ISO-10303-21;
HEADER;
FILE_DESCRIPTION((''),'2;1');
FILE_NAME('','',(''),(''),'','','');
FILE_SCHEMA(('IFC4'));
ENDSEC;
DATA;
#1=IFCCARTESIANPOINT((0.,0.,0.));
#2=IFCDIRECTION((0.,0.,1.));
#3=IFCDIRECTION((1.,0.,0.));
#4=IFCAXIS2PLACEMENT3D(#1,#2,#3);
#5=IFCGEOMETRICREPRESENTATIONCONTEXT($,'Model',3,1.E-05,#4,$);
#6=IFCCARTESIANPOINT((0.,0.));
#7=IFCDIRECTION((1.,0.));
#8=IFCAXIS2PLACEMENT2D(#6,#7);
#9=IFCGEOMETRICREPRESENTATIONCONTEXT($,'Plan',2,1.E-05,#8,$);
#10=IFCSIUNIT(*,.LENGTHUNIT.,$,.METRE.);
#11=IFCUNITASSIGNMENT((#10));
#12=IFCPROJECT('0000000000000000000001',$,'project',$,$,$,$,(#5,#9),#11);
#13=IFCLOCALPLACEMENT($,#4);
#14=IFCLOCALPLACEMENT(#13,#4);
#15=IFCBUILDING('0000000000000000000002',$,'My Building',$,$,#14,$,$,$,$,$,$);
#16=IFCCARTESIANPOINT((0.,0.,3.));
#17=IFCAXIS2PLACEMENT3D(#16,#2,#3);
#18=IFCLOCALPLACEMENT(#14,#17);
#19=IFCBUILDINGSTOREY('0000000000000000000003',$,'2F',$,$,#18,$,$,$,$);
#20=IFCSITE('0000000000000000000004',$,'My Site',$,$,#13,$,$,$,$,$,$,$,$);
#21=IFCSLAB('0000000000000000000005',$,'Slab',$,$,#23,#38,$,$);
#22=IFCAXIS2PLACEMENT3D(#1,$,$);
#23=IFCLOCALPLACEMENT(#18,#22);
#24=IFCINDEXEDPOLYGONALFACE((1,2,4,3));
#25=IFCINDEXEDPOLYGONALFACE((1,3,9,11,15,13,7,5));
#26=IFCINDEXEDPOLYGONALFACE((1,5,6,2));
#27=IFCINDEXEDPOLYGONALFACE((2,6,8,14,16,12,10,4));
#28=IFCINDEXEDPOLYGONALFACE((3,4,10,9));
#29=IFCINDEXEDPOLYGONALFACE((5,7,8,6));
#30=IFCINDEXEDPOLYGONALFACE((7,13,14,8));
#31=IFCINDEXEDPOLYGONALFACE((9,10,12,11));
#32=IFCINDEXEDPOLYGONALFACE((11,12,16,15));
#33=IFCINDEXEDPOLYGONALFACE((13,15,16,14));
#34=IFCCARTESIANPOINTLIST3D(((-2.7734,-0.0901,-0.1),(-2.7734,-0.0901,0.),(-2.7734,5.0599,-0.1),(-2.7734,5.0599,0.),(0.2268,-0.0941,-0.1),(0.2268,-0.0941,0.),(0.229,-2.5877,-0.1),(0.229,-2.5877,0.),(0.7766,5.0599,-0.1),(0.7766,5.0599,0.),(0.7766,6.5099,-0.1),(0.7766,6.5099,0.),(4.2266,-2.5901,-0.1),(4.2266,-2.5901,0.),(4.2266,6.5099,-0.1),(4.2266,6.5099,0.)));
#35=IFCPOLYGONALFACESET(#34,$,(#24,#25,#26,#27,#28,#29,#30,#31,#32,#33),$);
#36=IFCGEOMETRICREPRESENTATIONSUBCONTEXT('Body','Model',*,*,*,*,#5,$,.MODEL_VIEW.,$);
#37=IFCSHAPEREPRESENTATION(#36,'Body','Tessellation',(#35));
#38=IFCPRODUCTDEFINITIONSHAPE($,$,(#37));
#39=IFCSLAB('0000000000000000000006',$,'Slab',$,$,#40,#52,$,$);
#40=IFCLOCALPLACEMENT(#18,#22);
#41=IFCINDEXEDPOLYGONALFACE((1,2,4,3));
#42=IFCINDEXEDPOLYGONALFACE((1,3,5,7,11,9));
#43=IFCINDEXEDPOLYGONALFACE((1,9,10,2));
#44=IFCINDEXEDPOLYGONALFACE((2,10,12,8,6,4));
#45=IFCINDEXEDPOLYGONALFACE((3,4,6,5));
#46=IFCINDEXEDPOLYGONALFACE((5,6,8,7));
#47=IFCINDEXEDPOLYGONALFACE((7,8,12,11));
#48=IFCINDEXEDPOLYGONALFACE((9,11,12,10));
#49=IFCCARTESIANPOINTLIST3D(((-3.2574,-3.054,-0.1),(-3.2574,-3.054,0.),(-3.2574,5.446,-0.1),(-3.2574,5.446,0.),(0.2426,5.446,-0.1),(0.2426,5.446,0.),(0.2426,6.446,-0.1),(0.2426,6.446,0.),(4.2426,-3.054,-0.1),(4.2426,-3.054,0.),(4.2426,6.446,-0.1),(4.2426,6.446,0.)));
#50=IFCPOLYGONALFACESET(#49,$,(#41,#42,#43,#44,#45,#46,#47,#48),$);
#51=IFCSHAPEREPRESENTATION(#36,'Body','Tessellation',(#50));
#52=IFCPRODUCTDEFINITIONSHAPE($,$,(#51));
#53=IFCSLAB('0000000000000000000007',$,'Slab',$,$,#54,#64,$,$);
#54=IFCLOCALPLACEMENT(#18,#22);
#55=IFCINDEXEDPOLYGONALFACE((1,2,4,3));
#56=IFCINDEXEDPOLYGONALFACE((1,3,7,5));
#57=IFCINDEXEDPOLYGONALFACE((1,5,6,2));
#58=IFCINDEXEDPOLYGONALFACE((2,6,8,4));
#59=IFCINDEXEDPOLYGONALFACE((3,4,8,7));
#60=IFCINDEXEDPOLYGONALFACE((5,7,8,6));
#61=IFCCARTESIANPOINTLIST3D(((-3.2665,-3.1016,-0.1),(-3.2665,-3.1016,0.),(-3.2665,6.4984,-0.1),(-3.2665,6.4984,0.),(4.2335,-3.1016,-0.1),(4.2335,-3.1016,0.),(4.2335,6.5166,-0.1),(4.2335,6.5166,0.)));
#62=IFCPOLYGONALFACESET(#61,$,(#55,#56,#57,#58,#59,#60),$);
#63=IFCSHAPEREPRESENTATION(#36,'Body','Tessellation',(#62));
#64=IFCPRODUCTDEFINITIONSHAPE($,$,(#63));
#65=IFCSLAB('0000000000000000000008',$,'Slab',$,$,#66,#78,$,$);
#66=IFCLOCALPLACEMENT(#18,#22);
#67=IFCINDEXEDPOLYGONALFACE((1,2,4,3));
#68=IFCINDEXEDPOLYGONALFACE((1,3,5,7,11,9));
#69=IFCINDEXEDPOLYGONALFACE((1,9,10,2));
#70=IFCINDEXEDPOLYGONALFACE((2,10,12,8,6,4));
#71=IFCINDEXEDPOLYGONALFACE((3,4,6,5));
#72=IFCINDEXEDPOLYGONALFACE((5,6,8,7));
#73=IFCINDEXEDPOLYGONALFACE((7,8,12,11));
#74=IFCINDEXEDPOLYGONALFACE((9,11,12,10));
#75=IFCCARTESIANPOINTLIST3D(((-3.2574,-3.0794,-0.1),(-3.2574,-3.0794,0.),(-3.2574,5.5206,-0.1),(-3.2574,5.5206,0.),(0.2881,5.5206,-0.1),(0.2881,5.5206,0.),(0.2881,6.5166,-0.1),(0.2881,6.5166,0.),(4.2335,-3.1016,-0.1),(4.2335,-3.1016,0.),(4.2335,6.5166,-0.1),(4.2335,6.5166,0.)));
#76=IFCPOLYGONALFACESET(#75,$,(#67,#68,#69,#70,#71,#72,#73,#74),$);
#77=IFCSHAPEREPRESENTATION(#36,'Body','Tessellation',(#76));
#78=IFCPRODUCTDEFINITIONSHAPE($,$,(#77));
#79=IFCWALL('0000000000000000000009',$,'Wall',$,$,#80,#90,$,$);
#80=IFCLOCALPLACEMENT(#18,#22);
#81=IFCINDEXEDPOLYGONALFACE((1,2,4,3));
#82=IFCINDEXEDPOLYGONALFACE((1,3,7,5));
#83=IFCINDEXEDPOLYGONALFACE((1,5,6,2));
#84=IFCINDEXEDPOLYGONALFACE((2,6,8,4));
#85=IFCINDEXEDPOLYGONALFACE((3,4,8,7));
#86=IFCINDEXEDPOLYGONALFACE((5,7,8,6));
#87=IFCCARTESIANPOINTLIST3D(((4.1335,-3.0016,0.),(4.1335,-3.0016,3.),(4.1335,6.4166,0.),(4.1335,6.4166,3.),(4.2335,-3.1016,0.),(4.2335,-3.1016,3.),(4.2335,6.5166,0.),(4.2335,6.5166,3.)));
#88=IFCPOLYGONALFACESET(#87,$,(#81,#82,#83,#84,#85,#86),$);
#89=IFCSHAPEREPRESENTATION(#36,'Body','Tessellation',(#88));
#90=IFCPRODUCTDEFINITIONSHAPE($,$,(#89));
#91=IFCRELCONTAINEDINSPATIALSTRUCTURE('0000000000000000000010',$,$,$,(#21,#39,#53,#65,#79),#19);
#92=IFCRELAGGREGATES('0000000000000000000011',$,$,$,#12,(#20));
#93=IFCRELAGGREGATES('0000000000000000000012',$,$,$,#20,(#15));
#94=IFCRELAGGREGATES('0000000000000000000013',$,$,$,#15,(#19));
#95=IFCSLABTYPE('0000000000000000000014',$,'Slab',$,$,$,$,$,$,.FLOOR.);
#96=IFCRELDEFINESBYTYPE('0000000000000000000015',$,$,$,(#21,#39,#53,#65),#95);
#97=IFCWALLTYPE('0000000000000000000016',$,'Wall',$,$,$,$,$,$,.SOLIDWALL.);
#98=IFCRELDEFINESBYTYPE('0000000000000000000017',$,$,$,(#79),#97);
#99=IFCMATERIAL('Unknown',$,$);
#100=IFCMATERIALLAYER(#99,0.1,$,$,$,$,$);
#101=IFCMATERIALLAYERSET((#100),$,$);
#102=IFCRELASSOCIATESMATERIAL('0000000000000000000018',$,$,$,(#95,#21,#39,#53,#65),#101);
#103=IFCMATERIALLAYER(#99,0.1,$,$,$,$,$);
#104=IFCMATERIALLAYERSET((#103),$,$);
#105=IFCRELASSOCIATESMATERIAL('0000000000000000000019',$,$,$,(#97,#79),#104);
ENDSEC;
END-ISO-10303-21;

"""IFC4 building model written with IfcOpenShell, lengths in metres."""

from ifc_helpers import new_model, si_unit, frame, origin_with_axes, origin_2d_with_axis, place, context, subcontext, project, spatial, line, indexed_curve, outline, extrude, material, layer, layer_set, layer_usage, type_object, element, save


model = new_model("IFC4")

# Units and contexts
model_context = context("Model", 3, precision=1e-05, world=origin_with_axes())
plan_context = context("Plan", 2, precision=1e-05, world=origin_2d_with_axis())
body_context_1 = subcontext(model_context, "Body", "Model", "MODEL_VIEW")
ifc_project = project(units=[si_unit("LENGTHUNIT", "METRE")], contexts=[model_context, plan_context])

# Site, building, storey
site_placement = place(None, origin_with_axes())
site = spatial("IfcSite", under=ifc_project, at=site_placement, Name="My Site")
building_placement = place(site_placement, origin_with_axes())
building = spatial("IfcBuilding", under=site, at=building_placement, Name="My Building")
storey_placement = place(building_placement, frame((0.0, 0.0, 3.0), z_axis=(0.0, 0.0, 1.0), x_axis=(1.0, 0.0, 0.0)))
storey = spatial("IfcBuildingStorey", under=building, at=storey_placement, Name="2F")

# Slabs
ifc_material = material(Name="Unknown")
ifc_layer_1 = layer(ifc_material, 0.1)
ifc_layer_set_1 = layer_set([ifc_layer_1])
ifc_layer_usage_1 = layer_usage(ifc_layer_set_1, "AXIS3", "POSITIVE", -0.1)
slab_type = type_object("IfcSlabType", Name="Slab", PredefinedType="FLOOR", material=ifc_layer_set_1)
slab_1_placement = place(storey_placement, frame((0.229, -2.5877, 0.0), z_axis=(0.0, 0.0, 1.0), x_axis=(1.0, 0.0, 0.0)))
element("IfcSlab", 1, at=slab_1_placement, inside=storey, type_object=slab_type, material=ifc_layer_usage_1, Name="Slab", context=body_context_1, shape_type="SweptSolid", body=[
    extrude(outline(indexed_curve([(0.0, 0.0), (-0.0023, 2.4936), (-3.0024, 2.4976), (-3.0024, 7.6476), (0.5476, 7.6476), (0.5476, 9.0976), (3.9976, 9.0976), (3.9976, -0.0024), (0.0, 0.0)])), frame((0.0, 0.0, -0.1), z_axis=(0.0, 0.0, 1.0), x_axis=(1.0, 0.0, 0.0)), (0.0, 0.0, 1.0), 0.1),
])
ifc_layer_usage_2 = layer_usage(ifc_layer_set_1, "AXIS3", "POSITIVE", -0.1)
slab_2_placement = place(storey_placement, frame((4.2426, -3.054, 0.0), z_axis=(0.0, 0.0, 1.0), x_axis=(1.0, 0.0, 0.0)))
element("IfcSlab", 2, at=slab_2_placement, inside=storey, type_object=slab_type, material=ifc_layer_usage_2, Name="Slab", context=body_context_1, shape_type="SweptSolid", body=[
    extrude(outline(indexed_curve([(0.0, 0.0), (0.0, 9.5), (-4.0, 9.5), (-4.0, 8.5), (-7.5, 8.5), (-7.5, 0.0), (0.0, 0.0)])), frame((0.0, 0.0, -0.1), z_axis=(0.0, 0.0, 1.0), x_axis=(1.0, 0.0, 0.0)), (0.0, 0.0, 1.0), 0.1),
])
ifc_layer_usage_3 = layer_usage(ifc_layer_set_1, "AXIS3", "POSITIVE", -0.1)
slab_3_placement = place(storey_placement, frame((4.2335, -3.1016, 0.0), z_axis=(0.0, 0.0, 1.0), x_axis=(1.0, 0.0, 0.0)))
element("IfcSlab", 3, at=slab_3_placement, inside=storey, type_object=slab_type, material=ifc_layer_usage_3, Name="Slab", context=body_context_1, shape_type="SweptSolid", body=[
    extrude(outline(indexed_curve([(0.0, 0.0), (-7.5, 0.0), (-7.5, 9.6), (0.0, 9.6182), (0.0, 0.0)])), frame((0.0, 0.0, -0.1), z_axis=(0.0, 0.0, 1.0), x_axis=(1.0, 0.0, 0.0)), (0.0, 0.0, 1.0), 0.1),
])
ifc_layer_usage_4 = layer_usage(ifc_layer_set_1, "AXIS3", "POSITIVE", -0.1)
slab_4_placement = place(storey_placement, frame((4.2335, -3.1016, 0.0), z_axis=(0.0, 0.0, 1.0), x_axis=(1.0, 0.0, 0.0)))
element("IfcSlab", 4, at=slab_4_placement, inside=storey, type_object=slab_type, material=ifc_layer_usage_4, Name="Slab", context=body_context_1, shape_type="SweptSolid", body=[
    extrude(outline(indexed_curve([(0.0, 0.0), (0.0, 9.6182), (-3.9454, 9.6182), (-3.9454, 8.6222), (-7.4909, 8.6222), (-7.4909, 0.0222), (0.0, 0.0)])), frame((0.0, 0.0, -0.1), z_axis=(0.0, 0.0, 1.0), x_axis=(1.0, 0.0, 0.0)), (0.0, 0.0, 1.0), 0.1),
])

# Wall
ifc_layer_2 = layer(ifc_material, 0.1)
ifc_layer_set_2 = layer_set([ifc_layer_2])
ifc_layer_usage_5 = layer_usage(ifc_layer_set_2, "AXIS2", "POSITIVE", 0.0)
wall_type = type_object("IfcWallType", Name="Wall", PredefinedType="SOLIDWALL", material=ifc_layer_set_2)
wall_1_placement = place(storey_placement, frame((4.2335, -3.1016, 0.0), z_axis=(0.0, 0.0, 1.0), x_axis=(0.0, 1.0, 0.0)))
element("IfcWall", 5, at=wall_1_placement, inside=storey, type_object=wall_type, material=ifc_layer_usage_5, Name="Wall", context=body_context_1, shape_type="SweptSolid", body=[
    extrude(outline(indexed_curve([(0.0, 0.0), (0.1, 0.1), (9.5182, 0.1), (9.6182, 0.0)], segments=[line(1, 2, 3, 4, 1)])), origin_with_axes(), (0.0, 0.0, 1.0), 3.0),
])

save(model, "model.ifc")
